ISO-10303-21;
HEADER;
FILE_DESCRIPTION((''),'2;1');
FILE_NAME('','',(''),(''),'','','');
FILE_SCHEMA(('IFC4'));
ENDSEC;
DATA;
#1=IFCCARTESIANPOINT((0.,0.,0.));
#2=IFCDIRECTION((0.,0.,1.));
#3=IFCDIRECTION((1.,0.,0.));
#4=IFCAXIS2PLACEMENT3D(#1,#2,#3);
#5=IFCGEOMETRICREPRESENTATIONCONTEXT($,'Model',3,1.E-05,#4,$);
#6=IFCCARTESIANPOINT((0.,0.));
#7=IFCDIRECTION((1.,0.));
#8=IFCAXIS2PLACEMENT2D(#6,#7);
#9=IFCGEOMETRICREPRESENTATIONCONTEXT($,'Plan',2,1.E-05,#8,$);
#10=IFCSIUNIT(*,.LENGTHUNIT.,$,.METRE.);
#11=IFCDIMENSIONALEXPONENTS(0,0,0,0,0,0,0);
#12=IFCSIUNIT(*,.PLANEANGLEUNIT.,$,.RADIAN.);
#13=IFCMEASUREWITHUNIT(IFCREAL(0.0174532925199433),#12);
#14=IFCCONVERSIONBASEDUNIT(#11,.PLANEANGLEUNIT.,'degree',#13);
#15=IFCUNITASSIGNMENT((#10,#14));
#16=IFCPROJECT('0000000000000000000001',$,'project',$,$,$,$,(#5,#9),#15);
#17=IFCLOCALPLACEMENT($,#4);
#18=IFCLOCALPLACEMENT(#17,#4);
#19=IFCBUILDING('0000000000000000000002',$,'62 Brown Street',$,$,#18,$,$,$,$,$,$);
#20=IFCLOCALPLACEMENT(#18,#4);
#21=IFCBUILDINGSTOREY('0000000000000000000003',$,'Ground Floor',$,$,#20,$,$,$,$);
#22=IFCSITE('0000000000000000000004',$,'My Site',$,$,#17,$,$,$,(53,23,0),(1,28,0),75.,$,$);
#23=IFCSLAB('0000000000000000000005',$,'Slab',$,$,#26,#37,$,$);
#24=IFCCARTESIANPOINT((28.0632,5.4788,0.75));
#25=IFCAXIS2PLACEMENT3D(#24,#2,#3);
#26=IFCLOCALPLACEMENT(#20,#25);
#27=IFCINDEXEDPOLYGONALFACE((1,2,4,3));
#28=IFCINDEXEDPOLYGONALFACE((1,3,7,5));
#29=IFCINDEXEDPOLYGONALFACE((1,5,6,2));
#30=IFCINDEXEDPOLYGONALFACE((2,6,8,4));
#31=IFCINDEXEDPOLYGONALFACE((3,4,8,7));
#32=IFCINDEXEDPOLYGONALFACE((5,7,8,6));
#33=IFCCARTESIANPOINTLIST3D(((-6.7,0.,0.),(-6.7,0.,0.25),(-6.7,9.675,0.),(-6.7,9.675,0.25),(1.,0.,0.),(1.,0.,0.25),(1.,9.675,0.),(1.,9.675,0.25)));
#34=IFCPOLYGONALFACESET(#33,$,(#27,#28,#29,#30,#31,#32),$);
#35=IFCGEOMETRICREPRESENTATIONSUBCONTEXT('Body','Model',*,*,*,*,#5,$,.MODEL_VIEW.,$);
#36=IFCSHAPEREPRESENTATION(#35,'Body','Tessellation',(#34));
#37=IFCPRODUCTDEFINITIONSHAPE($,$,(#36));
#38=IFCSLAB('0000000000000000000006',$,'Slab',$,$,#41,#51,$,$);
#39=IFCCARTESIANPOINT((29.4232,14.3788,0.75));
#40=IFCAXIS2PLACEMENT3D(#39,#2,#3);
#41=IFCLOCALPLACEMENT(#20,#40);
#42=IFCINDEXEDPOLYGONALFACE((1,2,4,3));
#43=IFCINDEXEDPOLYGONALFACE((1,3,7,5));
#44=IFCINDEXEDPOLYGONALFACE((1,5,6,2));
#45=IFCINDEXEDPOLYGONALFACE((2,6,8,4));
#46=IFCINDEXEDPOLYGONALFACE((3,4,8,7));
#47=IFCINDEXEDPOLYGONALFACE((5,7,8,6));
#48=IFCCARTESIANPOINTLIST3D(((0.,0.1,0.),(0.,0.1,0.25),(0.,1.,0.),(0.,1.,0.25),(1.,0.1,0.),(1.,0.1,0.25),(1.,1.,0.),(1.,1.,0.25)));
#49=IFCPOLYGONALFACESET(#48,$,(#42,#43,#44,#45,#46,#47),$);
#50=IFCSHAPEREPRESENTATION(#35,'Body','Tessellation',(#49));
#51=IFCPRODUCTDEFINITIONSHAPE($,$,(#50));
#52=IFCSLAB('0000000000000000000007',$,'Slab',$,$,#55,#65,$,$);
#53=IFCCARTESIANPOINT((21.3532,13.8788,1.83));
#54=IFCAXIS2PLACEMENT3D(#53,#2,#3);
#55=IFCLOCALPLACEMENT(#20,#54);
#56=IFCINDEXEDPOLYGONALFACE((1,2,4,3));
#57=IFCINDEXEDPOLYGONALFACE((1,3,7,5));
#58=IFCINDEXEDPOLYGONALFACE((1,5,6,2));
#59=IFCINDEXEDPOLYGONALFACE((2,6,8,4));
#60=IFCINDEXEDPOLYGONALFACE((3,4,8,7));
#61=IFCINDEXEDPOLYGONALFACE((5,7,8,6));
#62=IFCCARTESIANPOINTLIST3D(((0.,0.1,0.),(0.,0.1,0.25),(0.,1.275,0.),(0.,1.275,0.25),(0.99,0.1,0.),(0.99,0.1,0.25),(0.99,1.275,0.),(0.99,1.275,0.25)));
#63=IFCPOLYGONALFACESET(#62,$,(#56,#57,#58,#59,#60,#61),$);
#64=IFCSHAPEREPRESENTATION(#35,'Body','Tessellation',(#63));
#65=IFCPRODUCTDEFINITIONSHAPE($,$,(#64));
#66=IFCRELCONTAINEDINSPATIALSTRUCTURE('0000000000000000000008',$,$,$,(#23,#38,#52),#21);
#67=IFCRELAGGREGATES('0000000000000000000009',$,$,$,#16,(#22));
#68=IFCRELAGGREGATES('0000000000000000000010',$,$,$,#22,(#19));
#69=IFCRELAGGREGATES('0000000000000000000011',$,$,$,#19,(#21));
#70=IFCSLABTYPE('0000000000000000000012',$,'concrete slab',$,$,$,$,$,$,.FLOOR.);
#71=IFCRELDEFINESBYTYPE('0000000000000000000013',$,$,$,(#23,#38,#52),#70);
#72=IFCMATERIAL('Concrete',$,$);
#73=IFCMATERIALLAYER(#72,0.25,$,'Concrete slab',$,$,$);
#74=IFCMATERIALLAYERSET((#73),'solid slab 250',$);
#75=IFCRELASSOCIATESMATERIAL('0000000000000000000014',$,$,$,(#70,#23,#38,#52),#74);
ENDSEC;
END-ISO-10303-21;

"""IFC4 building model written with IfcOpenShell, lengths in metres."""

from ifc_helpers import new_model, entity, si_unit, converted_unit, frame, origin_with_axes, origin_2d_with_axis, place, context, subcontext, project, spatial, line, indexed_curve, outline, extrude, material, layer, layer_set, layer_usage, type_object, element, save


model = new_model("IFC4")

# Units and contexts
model_context = context("Model", 3, precision=1e-05, world=origin_with_axes())
plan_context = context("Plan", 2, precision=1e-05, world=origin_2d_with_axis())
body_context_1 = subcontext(model_context, "Body", "Model", "MODEL_VIEW")
ifc_project = project(units=[si_unit("LENGTHUNIT", "METRE"), converted_unit("PLANEANGLEUNIT", "degree", entity("IfcReal", 0.0174532925199433), si_unit("PLANEANGLEUNIT", "RADIAN"), dimensions=[0, 0, 0, 0, 0, 0, 0])], contexts=[model_context, plan_context])

# Site, building, storey
site_placement = place(None, origin_with_axes())
site = spatial("IfcSite", under=ifc_project, at=site_placement, Name="My Site", RefLatitude=(53, 23, 0), RefLongitude=(1, 28, 0), RefElevation=75.0)
building_placement = place(site_placement, origin_with_axes())
building = spatial("IfcBuilding", under=site, at=building_placement, Name="62 Brown Street")
storey_placement = place(building_placement, origin_with_axes())
storey = spatial("IfcBuildingStorey", under=building, at=storey_placement, Name="Ground Floor")

# Shared definitions
ifc_material_1 = material(Name="Concrete")

# Slabs
ifc_layer_1 = layer(ifc_material_1, 0.25, Name="Concrete slab")
ifc_layer_set_1 = layer_set([ifc_layer_1], Name="solid slab 250")
slab_type = type_object("IfcSlabType", Name="concrete slab", PredefinedType="FLOOR", material=ifc_layer_set_1)
ifc_layer_usage_1 = layer_usage(ifc_layer_set_1, "AXIS3", "POSITIVE", 0.0)
slab_1_placement = place(storey_placement, frame((28.0632, 5.4788, 0.75), z_axis=(0.0, 0.0, 1.0), x_axis=(1.0, 0.0, 0.0)))
element("IfcSlab", 1, at=slab_1_placement, inside=storey, type_object=slab_type, material=ifc_layer_usage_1, Name="Slab", context=body_context_1, shape_type="SweptSolid", body=[
    extrude(outline(indexed_curve([(1.0, 9.675), (-6.7, 9.675), (-6.7, 0.0), (1.0, 0.0)], segments=[line(3, 2), line(2, 1), line(1, 4), line(4, 3)], self_intersect=False)), None, (0.0, 0.0, 1.0), 0.25),
])
ifc_layer_usage_2 = layer_usage(ifc_layer_set_1, "AXIS3", "POSITIVE", 0.0)
slab_2_placement = place(storey_placement, frame((29.4232, 14.3788, 0.75), z_axis=(0.0, 0.0, 1.0), x_axis=(1.0, 0.0, 0.0)))
element("IfcSlab", 2, at=slab_2_placement, inside=storey, type_object=slab_type, material=ifc_layer_usage_2, Name="Slab", context=body_context_1, shape_type="SweptSolid", body=[
    extrude(outline(indexed_curve([(1.0, 1.0), (1.0, 0.1), (0.0, 0.1), (0.0, 1.0)], segments=[line(3, 2), line(2, 1), line(1, 4), line(4, 3)], self_intersect=False)), None, (0.0, 0.0, 1.0), 0.25),
])
ifc_layer_usage_3 = layer_usage(ifc_layer_set_1, "AXIS3", "POSITIVE", 0.0)
slab_3_placement = place(storey_placement, frame((21.3532, 13.8788, 1.83), z_axis=(0.0, 0.0, 1.0), x_axis=(1.0, 0.0, 0.0)))
element("IfcSlab", 3, at=slab_3_placement, inside=storey, type_object=slab_type, material=ifc_layer_usage_3, Name="Slab", context=body_context_1, shape_type="SweptSolid", body=[
    extrude(outline(indexed_curve([(0.99, 1.275), (0.99, 0.1), (0.0, 0.1), (0.0, 1.275)], segments=[line(3, 2), line(2, 1), line(1, 4), line(4, 3)], self_intersect=False)), None, (0.0, 0.0, 1.0), 0.25),
])

save(model, "model.ifc")
